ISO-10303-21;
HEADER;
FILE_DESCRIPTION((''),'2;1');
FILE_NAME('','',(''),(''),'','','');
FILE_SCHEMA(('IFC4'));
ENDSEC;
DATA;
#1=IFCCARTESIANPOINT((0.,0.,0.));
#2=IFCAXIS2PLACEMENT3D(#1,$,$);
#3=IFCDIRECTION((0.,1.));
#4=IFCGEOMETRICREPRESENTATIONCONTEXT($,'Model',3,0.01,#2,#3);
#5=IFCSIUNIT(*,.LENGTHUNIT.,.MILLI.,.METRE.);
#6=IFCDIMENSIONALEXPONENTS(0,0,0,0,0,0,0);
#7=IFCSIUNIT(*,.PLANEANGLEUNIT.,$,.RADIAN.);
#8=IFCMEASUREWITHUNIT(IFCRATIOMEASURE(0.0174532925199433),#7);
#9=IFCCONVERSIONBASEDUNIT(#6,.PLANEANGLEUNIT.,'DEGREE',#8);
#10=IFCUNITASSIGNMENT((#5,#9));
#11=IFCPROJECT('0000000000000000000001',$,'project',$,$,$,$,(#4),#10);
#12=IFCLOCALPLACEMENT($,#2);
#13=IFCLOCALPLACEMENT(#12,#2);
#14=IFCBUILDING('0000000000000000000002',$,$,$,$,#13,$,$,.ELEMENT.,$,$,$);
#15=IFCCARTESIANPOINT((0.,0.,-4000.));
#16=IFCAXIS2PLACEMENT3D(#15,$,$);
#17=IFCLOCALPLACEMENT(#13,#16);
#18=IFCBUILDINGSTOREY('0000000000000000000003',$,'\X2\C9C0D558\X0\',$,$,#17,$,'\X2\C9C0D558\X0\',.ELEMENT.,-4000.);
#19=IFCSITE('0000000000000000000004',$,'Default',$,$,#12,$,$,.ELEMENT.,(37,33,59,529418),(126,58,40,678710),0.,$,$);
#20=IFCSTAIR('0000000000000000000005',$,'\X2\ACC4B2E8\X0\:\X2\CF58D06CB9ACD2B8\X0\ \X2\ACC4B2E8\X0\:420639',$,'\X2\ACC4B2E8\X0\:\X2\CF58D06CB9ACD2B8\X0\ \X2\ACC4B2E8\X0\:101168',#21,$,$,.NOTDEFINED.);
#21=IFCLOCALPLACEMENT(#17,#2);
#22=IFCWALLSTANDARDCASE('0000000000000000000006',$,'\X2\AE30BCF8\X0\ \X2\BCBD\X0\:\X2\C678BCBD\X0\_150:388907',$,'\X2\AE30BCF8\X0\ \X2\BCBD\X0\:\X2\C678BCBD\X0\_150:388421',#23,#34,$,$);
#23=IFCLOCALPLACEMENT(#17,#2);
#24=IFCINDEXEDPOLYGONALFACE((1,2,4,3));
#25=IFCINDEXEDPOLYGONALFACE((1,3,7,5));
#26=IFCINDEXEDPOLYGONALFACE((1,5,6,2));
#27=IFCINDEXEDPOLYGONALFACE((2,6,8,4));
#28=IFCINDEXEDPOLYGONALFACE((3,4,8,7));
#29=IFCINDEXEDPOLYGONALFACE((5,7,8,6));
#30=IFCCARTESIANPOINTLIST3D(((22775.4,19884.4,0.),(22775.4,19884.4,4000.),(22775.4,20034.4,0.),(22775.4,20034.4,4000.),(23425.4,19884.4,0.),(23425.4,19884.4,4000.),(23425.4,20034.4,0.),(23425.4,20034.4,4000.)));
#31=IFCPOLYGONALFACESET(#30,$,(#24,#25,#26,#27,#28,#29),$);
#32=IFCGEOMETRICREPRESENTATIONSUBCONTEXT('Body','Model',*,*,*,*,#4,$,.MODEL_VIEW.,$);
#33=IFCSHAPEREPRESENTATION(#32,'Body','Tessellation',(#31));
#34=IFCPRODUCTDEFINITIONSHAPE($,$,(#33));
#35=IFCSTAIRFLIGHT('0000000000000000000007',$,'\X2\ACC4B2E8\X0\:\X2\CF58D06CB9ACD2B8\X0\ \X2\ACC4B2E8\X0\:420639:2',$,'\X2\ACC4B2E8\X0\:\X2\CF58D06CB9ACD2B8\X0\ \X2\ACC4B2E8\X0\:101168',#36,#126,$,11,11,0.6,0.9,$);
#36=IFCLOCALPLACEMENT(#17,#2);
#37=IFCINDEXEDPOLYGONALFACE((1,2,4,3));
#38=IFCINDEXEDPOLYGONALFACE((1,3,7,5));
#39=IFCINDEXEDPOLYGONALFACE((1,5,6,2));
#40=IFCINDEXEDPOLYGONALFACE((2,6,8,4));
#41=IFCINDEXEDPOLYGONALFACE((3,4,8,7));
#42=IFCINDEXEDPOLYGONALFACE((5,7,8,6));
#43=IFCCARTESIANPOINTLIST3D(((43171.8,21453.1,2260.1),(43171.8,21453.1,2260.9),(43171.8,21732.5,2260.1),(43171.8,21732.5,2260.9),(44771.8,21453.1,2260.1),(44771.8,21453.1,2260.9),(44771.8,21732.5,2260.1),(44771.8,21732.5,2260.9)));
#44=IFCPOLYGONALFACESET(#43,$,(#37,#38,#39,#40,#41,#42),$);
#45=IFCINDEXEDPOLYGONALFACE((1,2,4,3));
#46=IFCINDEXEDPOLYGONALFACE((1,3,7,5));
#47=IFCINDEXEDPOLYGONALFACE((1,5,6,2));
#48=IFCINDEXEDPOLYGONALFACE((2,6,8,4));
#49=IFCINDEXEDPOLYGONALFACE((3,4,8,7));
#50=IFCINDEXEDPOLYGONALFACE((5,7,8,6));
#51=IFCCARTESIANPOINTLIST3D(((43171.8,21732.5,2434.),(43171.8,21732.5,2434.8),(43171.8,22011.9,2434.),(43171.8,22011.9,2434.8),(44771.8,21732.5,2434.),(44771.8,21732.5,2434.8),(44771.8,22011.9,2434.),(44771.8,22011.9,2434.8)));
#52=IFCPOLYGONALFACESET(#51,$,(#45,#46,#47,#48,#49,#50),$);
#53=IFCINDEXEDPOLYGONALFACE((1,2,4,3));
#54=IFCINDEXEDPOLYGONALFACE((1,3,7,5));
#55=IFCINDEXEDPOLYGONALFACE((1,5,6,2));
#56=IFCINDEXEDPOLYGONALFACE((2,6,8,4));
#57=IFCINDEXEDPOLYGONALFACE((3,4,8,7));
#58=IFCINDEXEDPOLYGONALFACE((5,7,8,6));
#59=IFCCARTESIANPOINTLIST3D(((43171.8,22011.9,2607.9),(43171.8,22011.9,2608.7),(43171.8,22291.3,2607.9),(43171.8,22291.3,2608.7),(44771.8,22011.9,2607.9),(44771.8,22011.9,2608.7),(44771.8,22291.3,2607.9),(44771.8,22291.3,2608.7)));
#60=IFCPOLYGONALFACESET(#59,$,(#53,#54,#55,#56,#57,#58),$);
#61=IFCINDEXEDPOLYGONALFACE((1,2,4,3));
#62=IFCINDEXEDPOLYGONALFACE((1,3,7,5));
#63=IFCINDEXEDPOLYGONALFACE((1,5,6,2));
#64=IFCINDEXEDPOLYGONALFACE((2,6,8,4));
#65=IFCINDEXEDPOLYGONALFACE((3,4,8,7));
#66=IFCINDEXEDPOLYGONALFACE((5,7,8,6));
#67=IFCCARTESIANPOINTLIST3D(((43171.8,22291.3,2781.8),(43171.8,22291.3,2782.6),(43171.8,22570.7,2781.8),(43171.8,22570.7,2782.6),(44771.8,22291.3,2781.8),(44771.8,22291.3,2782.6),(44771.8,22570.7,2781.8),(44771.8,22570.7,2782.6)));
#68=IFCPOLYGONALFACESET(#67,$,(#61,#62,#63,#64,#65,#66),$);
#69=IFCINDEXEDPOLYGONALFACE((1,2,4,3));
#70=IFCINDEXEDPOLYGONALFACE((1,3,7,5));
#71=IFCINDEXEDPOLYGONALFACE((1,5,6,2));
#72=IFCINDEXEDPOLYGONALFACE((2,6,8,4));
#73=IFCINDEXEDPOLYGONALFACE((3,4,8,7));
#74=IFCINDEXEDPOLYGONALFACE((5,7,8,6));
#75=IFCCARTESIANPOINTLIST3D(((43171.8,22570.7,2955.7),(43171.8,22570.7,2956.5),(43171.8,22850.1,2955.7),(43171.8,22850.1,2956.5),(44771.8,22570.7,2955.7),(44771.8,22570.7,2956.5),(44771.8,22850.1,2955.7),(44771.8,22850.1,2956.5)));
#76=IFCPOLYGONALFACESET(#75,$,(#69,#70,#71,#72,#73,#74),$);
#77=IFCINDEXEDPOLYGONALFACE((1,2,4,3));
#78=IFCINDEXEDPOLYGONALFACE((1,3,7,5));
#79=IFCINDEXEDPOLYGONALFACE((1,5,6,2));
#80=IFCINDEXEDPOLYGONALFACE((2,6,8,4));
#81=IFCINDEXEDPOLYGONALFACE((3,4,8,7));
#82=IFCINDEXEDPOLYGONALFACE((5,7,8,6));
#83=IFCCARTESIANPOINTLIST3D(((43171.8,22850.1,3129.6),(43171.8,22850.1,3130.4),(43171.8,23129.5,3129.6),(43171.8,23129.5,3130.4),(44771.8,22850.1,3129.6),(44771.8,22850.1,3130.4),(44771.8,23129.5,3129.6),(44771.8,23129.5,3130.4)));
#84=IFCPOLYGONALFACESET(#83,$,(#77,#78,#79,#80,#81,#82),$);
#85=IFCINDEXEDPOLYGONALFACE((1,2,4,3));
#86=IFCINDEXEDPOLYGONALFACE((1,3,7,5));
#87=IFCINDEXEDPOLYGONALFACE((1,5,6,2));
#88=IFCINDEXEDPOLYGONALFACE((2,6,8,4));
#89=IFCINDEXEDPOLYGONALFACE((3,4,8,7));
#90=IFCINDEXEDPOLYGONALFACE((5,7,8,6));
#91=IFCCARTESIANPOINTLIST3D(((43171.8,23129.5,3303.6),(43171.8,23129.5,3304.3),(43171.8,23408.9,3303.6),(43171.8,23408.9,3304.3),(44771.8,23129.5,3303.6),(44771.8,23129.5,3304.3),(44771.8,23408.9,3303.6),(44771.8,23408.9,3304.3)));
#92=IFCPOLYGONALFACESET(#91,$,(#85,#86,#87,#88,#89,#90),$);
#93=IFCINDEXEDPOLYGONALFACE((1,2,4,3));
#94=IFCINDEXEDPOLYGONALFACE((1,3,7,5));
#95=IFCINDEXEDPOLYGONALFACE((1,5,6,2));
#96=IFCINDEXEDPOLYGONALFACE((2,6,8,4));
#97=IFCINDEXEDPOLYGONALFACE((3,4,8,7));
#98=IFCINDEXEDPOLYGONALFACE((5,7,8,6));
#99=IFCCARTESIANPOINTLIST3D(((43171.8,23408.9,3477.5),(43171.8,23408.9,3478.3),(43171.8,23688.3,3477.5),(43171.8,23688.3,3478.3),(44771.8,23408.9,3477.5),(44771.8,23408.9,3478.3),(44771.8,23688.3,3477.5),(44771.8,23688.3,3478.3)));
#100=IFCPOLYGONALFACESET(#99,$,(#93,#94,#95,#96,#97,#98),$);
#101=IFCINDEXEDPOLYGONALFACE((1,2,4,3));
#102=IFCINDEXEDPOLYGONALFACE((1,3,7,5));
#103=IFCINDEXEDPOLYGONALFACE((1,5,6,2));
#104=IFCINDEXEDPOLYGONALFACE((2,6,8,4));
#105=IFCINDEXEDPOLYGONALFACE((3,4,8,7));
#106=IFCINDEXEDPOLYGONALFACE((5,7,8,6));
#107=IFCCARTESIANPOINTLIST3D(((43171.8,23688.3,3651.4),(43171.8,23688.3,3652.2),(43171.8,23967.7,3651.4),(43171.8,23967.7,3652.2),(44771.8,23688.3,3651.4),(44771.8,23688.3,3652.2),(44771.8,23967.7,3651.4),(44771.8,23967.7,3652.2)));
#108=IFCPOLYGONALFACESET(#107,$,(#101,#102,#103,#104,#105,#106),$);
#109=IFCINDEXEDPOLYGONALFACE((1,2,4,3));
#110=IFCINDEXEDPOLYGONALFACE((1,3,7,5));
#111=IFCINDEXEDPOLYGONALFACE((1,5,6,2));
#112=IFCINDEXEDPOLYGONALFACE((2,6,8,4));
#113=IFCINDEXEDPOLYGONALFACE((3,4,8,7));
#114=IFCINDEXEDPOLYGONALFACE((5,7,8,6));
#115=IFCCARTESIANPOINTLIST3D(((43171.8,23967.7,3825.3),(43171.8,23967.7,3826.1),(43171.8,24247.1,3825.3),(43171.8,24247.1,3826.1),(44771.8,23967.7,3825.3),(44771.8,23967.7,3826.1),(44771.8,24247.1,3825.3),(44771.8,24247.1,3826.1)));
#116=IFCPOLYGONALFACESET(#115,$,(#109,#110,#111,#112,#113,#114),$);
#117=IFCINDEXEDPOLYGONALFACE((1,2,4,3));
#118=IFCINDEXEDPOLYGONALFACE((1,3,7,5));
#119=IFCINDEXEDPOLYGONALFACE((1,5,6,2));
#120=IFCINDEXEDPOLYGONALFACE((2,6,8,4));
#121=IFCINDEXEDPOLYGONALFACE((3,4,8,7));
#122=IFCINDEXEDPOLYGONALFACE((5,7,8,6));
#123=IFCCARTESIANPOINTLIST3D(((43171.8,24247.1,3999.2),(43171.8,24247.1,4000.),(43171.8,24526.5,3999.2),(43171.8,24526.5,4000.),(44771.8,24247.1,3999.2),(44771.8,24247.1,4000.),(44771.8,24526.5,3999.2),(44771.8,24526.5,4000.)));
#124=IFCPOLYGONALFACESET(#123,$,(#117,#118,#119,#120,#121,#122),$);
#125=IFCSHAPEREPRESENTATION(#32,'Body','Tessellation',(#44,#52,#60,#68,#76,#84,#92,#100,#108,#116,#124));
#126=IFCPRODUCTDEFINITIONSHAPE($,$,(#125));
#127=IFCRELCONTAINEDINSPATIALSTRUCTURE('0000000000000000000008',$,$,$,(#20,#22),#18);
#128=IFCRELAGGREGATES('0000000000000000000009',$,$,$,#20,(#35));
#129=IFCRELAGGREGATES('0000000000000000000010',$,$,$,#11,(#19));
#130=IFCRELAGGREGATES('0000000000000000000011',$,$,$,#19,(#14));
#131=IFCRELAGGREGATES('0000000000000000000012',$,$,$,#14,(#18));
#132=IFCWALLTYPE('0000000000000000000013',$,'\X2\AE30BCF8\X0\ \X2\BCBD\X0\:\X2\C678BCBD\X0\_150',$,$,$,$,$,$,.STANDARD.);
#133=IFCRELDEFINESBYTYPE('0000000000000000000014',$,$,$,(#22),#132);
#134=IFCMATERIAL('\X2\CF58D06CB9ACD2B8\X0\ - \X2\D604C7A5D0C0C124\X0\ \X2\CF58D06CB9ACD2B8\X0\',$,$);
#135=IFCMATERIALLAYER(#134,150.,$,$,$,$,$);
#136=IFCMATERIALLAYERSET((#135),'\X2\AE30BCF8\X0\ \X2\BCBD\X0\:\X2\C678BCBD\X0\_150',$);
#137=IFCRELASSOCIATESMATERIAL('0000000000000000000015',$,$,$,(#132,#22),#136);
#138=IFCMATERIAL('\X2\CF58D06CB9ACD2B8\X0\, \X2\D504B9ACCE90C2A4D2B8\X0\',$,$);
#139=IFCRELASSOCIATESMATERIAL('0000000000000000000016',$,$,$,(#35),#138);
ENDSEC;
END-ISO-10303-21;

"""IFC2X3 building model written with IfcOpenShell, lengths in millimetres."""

from ifc_helpers import new_model, entity, si_unit, converted_unit, direction, frame, frame_2d, origin, place, context, subcontext, project, spatial, rectangle, extrude, material, layer, layer_set, layer_usage, type_object, element, aggregate, save


model = new_model("IFC2X3")

# Units and contexts
model_context = context("Model", 3, precision=0.01, world=origin(), true_north=direction((0.0, 1.0)))
body_context = subcontext(model_context, "Body", "Model", "MODEL_VIEW")
ifc_project = project(units=[si_unit("LENGTHUNIT", "METRE", prefix="MILLI"), converted_unit("PLANEANGLEUNIT", "DEGREE", entity("IfcRatioMeasure", 0.0174532925199433), si_unit("PLANEANGLEUNIT", "RADIAN"), dimensions=[0, 0, 0, 0, 0, 0, 0])], contexts=[model_context])

# Site, building, storey
site_placement = place(None, origin())
site = spatial("IfcSite", under=ifc_project, at=site_placement, Name="Default", CompositionType="ELEMENT", RefLatitude=(37, 33, 59, 529418), RefLongitude=(126, 58, 40, 678710), RefElevation=0.0)
building_placement = place(site_placement, origin())
building = spatial("IfcBuilding", under=site, at=building_placement, CompositionType="ELEMENT")
storey_placement = place(building_placement, frame((0.0, 0.0, -4000.0)))
storey = spatial("IfcBuildingStorey", under=building, at=storey_placement, Name="지하", LongName="지하", CompositionType="ELEMENT", Elevation=-4000.0)

# Shared definitions
ifc_material_1 = material(Name="콘크리트 - 현장타설 콘크리트")

# Stair
stair_placement = place(storey_placement, origin())
stair = element("IfcStair", 1, at=stair_placement, inside=storey, Name="계단:콘크리트 계단:420639", ObjectType="계단:콘크리트 계단:101168", ShapeType="NOTDEFINED")
ifc_material_2 = material(Name="콘크리트, 프리캐스트")

# Wall
ifc_layer_1 = layer(ifc_material_1, 150.0)
ifc_layer_set_1 = layer_set([ifc_layer_1], Name="기본 벽:외벽_150")
wall_type_1 = type_object("IfcWallType", Name="기본 벽:외벽_150", PredefinedType="STANDARD", material=ifc_layer_set_1)
ifc_layer_usage_1 = layer_usage(ifc_layer_set_1, "AXIS2", "NEGATIVE", 75.0)
wall_1_placement = place(storey_placement, frame((23425.4, 19959.4, 0.0), z_axis=(0.0, 0.0, 1.0), x_axis=(-1.0, 0.0, 0.0)))
element("IfcWallStandardCase", 2, at=wall_1_placement, inside=storey, type_object=wall_type_1, material=ifc_layer_usage_1, Name="기본 벽:외벽_150:388907", ObjectType="기본 벽:외벽_150:388421", context=body_context, shape_type="SweptSolid", body=[
    extrude(rectangle(XDim=650.0, YDim=150.0, at=frame_2d((325.0, 0.0), x_axis=(-1.0, 0.0))), origin(), (0.0, 0.0, 1.0), 4000.0),
])

# Stair flight
stair_flight_placement = place(stair_placement, origin())
stair_flight = element("IfcStairFlight", 3, at=stair_flight_placement, material=ifc_material_2, Name="계단:콘크리트 계단:420639:2", ObjectType="계단:콘크리트 계단:101168", NumberOfRiser=11, NumberOfTreads=11, RiserHeight=0.6, TreadLength=0.9, context=body_context, shape_type="SweptSolid", body=[
    extrude(rectangle(XDim=279.4, YDim=1600.0, at=frame_2d((0.0, 0.0), x_axis=(1.0, 0.0))), frame((43971.8, 21592.8, 2260.1), z_axis=(0.0, 0.0, 1.0), x_axis=(0.0, -1.0, 0.0)), (0.0, 0.0, 1.0), 0.8),
    extrude(rectangle(XDim=279.4, YDim=1600.0, at=frame_2d((0.0, 0.0), x_axis=(1.0, 0.0))), frame((43971.8, 21872.2, 2434.0), z_axis=(0.0, 0.0, 1.0), x_axis=(0.0, -1.0, 0.0)), (0.0, 0.0, 1.0), 0.8),
    extrude(rectangle(XDim=279.4, YDim=1600.0, at=frame_2d((0.0, 0.0), x_axis=(1.0, 0.0))), frame((43971.8, 22151.6, 2607.9), z_axis=(0.0, 0.0, 1.0), x_axis=(0.0, -1.0, 0.0)), (0.0, 0.0, 1.0), 0.8),
    extrude(rectangle(XDim=279.4, YDim=1600.0, at=frame_2d((0.0, 0.0), x_axis=(1.0, 0.0))), frame((43971.8, 22431.0, 2781.8), z_axis=(0.0, 0.0, 1.0), x_axis=(0.0, -1.0, 0.0)), (0.0, 0.0, 1.0), 0.8),
    extrude(rectangle(XDim=279.4, YDim=1600.0, at=frame_2d((0.0, 0.0), x_axis=(1.0, 0.0))), frame((43971.8, 22710.4, 2955.7), z_axis=(0.0, 0.0, 1.0), x_axis=(0.0, -1.0, 0.0)), (0.0, 0.0, 1.0), 0.8),
    extrude(rectangle(XDim=279.4, YDim=1600.0, at=frame_2d((0.0, 0.0), x_axis=(1.0, 0.0))), frame((43971.8, 22989.8, 3129.6), z_axis=(0.0, 0.0, 1.0), x_axis=(0.0, -1.0, 0.0)), (0.0, 0.0, 1.0), 0.8),
    extrude(rectangle(XDim=279.4, YDim=1600.0, at=frame_2d((0.0, 0.0), x_axis=(1.0, 0.0))), frame((43971.8, 23269.2, 3303.6), z_axis=(0.0, 0.0, 1.0), x_axis=(0.0, -1.0, 0.0)), (0.0, 0.0, 1.0), 0.8),
    extrude(rectangle(XDim=279.4, YDim=1600.0, at=frame_2d((0.0, 0.0), x_axis=(1.0, 0.0))), frame((43971.8, 23548.6, 3477.5), z_axis=(0.0, 0.0, 1.0), x_axis=(0.0, -1.0, 0.0)), (0.0, 0.0, 1.0), 0.8),
    extrude(rectangle(XDim=279.4, YDim=1600.0, at=frame_2d((0.0, 0.0), x_axis=(1.0, 0.0))), frame((43971.8, 23828.0, 3651.4), z_axis=(0.0, 0.0, 1.0), x_axis=(0.0, -1.0, 0.0)), (0.0, 0.0, 1.0), 0.8),
    extrude(rectangle(XDim=279.4, YDim=1600.0, at=frame_2d((0.0, 0.0), x_axis=(1.0, 0.0))), frame((43971.8, 24107.4, 3825.3), z_axis=(0.0, 0.0, 1.0), x_axis=(0.0, -1.0, 0.0)), (0.0, 0.0, 1.0), 0.8),
    extrude(rectangle(XDim=279.4, YDim=1600.0, at=frame_2d((0.0, 0.0), x_axis=(1.0, 0.0))), frame((43971.8, 24386.8, 3999.2), z_axis=(0.0, 0.0, 1.0), x_axis=(0.0, -1.0, 0.0)), (0.0, 0.0, 1.0), 0.8),
])
aggregate(stair, [stair_flight])

save(model, "model.ifc")
